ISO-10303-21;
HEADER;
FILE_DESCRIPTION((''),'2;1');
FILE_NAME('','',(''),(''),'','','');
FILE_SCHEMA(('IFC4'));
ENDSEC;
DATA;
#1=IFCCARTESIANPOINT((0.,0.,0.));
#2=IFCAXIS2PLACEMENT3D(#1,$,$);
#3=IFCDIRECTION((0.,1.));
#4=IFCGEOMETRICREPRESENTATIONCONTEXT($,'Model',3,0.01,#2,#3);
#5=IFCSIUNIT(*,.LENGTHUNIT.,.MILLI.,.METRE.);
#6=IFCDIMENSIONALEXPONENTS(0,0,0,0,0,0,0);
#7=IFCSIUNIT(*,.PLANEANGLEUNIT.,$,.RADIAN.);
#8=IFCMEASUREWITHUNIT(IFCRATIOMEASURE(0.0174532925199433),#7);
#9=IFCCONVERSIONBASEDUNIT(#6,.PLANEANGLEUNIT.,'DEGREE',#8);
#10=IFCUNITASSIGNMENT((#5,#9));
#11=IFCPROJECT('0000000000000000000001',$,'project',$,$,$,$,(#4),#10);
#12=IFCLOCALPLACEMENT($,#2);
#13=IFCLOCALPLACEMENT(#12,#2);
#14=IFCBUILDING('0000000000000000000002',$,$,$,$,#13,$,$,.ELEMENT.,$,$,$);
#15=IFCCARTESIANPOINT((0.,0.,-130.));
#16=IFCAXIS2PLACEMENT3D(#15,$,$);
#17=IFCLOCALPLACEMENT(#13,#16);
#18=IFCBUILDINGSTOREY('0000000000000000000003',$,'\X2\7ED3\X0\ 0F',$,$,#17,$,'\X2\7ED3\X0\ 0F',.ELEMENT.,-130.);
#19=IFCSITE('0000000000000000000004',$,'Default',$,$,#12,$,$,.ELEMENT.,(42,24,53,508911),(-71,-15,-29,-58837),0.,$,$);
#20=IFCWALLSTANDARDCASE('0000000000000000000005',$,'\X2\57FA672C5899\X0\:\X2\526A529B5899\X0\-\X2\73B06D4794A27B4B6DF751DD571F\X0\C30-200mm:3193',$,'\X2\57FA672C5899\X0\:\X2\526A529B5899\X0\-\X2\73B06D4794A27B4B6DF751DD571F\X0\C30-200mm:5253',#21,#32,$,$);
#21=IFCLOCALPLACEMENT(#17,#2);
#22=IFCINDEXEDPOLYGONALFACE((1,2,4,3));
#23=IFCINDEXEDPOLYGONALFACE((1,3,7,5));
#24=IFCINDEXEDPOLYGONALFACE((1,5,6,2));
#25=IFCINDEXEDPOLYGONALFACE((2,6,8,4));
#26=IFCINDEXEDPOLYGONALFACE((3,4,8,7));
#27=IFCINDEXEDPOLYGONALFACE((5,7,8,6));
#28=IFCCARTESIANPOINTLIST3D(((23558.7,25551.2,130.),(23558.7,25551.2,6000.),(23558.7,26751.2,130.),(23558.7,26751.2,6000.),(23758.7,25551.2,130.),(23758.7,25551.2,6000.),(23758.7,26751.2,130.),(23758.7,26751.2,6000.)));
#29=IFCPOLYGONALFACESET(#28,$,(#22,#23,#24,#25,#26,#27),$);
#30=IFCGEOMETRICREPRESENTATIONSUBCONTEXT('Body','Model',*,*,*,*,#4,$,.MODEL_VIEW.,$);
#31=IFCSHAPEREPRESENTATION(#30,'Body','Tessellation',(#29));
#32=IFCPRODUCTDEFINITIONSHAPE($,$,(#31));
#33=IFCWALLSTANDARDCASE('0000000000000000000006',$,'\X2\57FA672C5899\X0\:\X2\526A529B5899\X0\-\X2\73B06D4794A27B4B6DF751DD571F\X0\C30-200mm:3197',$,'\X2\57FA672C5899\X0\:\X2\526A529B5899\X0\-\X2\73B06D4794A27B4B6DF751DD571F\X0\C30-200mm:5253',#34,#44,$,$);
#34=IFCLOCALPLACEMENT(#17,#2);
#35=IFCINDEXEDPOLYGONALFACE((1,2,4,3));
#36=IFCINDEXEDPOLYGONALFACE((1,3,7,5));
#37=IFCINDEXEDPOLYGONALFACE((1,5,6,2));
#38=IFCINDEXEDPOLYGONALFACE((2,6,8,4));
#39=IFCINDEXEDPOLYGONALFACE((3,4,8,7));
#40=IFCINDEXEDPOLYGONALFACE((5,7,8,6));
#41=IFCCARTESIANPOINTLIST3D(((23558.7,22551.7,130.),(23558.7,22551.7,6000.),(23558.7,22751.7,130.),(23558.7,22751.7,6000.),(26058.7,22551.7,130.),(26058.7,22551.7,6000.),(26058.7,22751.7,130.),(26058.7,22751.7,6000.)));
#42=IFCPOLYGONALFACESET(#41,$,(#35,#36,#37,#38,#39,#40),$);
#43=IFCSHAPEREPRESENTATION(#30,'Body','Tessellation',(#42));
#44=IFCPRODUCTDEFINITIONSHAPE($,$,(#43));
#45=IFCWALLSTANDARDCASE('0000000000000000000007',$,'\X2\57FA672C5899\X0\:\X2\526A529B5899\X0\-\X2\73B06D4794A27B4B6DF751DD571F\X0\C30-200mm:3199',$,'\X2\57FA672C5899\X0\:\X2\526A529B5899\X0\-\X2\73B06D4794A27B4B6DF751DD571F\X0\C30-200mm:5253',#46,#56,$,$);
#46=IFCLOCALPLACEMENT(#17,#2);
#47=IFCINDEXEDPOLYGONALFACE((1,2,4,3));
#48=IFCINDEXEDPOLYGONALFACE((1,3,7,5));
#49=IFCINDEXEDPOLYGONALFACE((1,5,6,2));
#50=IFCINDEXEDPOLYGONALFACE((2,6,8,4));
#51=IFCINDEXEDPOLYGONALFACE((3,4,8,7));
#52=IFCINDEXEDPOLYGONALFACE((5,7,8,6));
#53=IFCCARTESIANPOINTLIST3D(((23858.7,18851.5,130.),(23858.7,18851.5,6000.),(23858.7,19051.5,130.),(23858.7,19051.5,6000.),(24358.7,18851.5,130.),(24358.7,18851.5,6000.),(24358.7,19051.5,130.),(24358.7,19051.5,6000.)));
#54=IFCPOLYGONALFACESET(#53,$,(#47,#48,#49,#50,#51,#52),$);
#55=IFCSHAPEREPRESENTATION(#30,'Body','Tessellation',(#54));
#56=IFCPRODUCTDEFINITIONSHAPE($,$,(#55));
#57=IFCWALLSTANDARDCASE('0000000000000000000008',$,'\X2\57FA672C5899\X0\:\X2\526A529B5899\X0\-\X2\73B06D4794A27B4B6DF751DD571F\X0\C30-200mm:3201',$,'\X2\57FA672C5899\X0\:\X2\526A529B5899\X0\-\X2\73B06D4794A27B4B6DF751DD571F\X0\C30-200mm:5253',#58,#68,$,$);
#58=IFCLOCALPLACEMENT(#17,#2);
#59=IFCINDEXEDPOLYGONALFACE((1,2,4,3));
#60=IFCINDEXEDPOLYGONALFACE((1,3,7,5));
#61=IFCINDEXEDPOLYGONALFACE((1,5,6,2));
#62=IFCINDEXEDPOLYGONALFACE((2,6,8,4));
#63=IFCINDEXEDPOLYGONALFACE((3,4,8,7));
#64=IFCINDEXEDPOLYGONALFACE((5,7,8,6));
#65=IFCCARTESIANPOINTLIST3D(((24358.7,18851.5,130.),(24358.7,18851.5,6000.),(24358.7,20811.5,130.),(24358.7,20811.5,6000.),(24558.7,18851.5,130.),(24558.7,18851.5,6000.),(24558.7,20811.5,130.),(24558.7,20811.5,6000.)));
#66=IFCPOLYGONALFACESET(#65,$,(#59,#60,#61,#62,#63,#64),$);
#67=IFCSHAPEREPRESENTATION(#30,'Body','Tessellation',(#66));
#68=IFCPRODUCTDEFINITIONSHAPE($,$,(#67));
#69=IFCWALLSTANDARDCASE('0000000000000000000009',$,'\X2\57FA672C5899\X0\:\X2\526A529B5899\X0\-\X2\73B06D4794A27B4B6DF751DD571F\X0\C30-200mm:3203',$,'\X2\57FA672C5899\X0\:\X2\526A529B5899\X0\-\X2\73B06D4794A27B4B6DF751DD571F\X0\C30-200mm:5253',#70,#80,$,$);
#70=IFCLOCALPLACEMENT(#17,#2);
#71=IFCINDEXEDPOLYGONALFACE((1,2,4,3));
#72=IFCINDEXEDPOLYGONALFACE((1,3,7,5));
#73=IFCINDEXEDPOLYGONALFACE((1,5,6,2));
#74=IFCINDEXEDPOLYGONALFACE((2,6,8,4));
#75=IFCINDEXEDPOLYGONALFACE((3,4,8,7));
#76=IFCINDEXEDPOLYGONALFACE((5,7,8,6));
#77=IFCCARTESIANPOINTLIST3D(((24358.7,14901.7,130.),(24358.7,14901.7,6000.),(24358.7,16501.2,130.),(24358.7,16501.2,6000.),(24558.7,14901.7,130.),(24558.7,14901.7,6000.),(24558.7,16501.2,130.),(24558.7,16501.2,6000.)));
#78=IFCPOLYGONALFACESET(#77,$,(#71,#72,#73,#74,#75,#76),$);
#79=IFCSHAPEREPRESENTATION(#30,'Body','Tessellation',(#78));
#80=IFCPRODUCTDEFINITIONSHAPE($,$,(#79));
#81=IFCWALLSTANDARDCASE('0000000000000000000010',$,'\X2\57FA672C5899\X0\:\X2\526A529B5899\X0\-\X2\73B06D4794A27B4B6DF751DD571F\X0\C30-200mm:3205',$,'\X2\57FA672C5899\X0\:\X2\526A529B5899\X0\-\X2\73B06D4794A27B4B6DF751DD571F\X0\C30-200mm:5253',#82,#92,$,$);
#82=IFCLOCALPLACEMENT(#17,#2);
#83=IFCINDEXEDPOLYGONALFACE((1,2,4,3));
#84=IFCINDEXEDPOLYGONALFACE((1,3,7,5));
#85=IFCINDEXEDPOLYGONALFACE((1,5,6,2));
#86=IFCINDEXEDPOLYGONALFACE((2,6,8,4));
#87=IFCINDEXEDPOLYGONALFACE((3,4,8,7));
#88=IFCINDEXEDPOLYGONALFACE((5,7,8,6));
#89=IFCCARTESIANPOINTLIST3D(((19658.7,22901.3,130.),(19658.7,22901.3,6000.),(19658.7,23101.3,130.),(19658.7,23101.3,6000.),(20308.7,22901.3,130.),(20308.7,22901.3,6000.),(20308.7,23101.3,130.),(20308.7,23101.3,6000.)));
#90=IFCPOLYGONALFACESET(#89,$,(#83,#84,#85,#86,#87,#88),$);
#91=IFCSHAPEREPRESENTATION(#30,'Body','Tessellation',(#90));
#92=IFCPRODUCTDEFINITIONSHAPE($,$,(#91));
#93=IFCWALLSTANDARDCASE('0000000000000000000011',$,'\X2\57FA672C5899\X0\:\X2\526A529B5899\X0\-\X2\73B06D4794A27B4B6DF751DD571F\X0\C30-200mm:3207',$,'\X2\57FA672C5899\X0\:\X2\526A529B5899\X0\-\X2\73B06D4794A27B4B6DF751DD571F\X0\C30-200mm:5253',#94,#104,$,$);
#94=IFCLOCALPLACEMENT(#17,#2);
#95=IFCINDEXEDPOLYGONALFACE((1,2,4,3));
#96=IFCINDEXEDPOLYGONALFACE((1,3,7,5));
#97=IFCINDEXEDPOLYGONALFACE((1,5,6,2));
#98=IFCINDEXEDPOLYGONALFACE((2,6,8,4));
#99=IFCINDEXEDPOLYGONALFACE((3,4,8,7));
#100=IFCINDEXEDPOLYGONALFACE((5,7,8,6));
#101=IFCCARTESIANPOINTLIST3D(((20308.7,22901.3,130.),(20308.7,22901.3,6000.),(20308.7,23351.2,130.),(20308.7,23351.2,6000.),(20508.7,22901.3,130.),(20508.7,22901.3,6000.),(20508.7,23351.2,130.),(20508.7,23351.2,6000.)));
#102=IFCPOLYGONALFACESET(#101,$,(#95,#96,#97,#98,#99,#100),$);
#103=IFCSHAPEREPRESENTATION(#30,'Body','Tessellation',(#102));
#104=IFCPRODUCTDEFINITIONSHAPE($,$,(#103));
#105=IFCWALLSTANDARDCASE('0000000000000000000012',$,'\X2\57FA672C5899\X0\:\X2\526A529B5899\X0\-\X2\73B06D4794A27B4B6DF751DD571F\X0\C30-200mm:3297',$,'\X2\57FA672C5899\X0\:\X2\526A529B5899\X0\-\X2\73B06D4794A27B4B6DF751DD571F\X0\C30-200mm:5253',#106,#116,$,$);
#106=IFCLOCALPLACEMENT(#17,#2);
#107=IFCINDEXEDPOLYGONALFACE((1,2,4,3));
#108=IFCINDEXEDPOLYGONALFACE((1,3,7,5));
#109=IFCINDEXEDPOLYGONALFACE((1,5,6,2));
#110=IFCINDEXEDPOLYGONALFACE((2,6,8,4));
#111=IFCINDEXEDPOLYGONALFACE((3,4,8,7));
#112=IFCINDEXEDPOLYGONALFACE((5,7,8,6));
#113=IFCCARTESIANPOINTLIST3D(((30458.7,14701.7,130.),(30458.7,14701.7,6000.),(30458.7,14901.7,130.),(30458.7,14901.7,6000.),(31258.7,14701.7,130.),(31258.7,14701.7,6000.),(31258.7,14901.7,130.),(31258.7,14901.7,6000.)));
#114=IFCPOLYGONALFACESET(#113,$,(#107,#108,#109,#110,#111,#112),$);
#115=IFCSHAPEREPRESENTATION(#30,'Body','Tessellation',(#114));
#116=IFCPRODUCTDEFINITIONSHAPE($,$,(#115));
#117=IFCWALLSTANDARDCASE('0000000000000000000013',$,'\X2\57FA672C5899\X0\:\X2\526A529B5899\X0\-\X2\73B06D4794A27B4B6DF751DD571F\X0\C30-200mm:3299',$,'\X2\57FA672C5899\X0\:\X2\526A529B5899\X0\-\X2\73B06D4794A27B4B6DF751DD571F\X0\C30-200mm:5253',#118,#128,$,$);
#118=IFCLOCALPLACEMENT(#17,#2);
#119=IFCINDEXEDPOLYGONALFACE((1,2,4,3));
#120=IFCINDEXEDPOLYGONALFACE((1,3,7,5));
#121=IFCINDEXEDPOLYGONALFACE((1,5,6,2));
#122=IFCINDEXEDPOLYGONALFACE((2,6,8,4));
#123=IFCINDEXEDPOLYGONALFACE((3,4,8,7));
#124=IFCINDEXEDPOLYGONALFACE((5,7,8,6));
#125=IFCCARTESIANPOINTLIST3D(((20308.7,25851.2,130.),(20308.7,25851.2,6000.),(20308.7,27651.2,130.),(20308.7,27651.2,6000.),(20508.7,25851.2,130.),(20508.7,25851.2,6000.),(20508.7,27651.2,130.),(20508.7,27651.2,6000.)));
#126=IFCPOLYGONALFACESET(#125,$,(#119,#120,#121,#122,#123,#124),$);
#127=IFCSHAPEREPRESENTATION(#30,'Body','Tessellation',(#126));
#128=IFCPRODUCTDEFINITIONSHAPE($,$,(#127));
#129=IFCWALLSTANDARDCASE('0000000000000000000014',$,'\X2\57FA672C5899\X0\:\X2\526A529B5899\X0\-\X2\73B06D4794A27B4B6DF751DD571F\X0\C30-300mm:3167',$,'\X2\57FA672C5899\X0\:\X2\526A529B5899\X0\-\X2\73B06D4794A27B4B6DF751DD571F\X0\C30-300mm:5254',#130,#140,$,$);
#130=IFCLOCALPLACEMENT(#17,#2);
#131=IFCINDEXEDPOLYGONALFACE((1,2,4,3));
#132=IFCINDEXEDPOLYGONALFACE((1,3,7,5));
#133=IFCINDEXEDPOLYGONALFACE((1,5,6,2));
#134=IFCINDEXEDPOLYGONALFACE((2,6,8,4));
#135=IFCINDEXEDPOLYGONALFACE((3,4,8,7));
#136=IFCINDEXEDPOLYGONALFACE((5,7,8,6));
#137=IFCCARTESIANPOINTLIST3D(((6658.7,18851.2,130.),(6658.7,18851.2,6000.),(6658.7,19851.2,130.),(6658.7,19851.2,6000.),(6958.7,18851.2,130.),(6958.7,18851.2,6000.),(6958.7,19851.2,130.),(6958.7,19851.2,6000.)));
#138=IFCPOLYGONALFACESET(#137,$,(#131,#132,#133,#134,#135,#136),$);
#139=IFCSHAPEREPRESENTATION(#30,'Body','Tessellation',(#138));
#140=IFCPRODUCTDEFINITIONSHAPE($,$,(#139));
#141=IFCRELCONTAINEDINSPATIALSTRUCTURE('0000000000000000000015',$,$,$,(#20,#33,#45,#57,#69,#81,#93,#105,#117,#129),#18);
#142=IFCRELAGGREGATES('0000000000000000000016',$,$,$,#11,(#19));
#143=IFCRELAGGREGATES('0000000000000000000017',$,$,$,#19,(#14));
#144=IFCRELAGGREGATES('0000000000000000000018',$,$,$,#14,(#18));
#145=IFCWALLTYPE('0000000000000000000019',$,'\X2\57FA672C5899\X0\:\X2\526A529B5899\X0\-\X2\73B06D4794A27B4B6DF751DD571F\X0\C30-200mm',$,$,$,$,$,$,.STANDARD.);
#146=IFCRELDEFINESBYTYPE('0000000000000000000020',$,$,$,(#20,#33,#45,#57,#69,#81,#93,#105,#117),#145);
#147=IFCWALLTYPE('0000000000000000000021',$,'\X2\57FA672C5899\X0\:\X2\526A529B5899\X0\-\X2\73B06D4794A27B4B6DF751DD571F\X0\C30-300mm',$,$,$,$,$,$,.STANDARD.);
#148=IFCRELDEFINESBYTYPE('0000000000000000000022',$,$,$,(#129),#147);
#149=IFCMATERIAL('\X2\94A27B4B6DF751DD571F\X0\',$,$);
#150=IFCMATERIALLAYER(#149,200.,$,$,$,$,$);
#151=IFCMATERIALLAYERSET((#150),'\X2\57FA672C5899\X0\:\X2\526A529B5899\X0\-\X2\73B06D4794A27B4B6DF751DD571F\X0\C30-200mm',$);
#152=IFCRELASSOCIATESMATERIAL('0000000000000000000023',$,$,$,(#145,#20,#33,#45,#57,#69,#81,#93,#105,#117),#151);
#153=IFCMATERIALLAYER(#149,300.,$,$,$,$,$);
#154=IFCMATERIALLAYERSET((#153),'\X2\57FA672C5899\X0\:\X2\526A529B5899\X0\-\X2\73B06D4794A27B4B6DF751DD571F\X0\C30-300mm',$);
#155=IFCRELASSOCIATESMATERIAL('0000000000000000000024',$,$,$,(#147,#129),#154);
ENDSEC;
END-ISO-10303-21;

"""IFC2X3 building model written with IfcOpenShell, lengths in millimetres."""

from ifc_helpers import new_model, entity, si_unit, converted_unit, direction, frame, frame_2d, origin, place, context, subcontext, project, spatial, rectangle, extrude, material, layer, layer_set, layer_usage, type_object, element, save


model = new_model("IFC2X3")

# Units and contexts
model_context = context("Model", 3, precision=0.01, world=origin(), true_north=direction((0.0, 1.0)))
body_context = subcontext(model_context, "Body", "Model", "MODEL_VIEW")
ifc_project = project(units=[si_unit("LENGTHUNIT", "METRE", prefix="MILLI"), converted_unit("PLANEANGLEUNIT", "DEGREE", entity("IfcRatioMeasure", 0.0174532925199433), si_unit("PLANEANGLEUNIT", "RADIAN"), dimensions=[0, 0, 0, 0, 0, 0, 0])], contexts=[model_context])

# Site, building, storey
site_placement = place(None, origin())
site = spatial("IfcSite", under=ifc_project, at=site_placement, Name="Default", CompositionType="ELEMENT", RefLatitude=(42, 24, 53, 508911), RefLongitude=(-71, -15, -29, -58837), RefElevation=0.0)
building_placement = place(site_placement, origin())
building = spatial("IfcBuilding", under=site, at=building_placement, CompositionType="ELEMENT")
storey_placement = place(building_placement, frame((0.0, 0.0, -130.0)))
storey = spatial("IfcBuildingStorey", under=building, at=storey_placement, Name="结 0F", LongName="结 0F", CompositionType="ELEMENT", Elevation=-130.0)

# Walls
ifc_material = material(Name="钢筋混凝土")
ifc_layer_1 = layer(ifc_material, 200.0)
ifc_layer_set_1 = layer_set([ifc_layer_1], Name="基本墙:剪力墙-现浇钢筋混凝土C30-200mm")
wall_type_1 = type_object("IfcWallType", Name="基本墙:剪力墙-现浇钢筋混凝土C30-200mm", PredefinedType="STANDARD", material=ifc_layer_set_1)
ifc_layer_usage_1 = layer_usage(ifc_layer_set_1, "AXIS2", "POSITIVE", -100.0)
wall_1_placement = place(storey_placement, frame((23658.7, 26751.2, 130.0), z_axis=(0.0, 0.0, 1.0), x_axis=(0.0, -1.0, 0.0)))
element("IfcWallStandardCase", 1, at=wall_1_placement, inside=storey, type_object=wall_type_1, material=ifc_layer_usage_1, Name="基本墙:剪力墙-现浇钢筋混凝土C30-200mm:3193", ObjectType="基本墙:剪力墙-现浇钢筋混凝土C30-200mm:5253", context=body_context, shape_type="SweptSolid", body=[
    extrude(rectangle(XDim=1200.0, YDim=200.0, at=frame_2d((600.0, 0.0), x_axis=(-1.0, 0.0))), origin(), (0.0, 0.0, 1.0), 5870.0),
])
ifc_layer_usage_2 = layer_usage(ifc_layer_set_1, "AXIS2", "POSITIVE", -100.0)
wall_2_placement = place(storey_placement, frame((26058.7, 22651.7, 130.0), z_axis=(0.0, 0.0, 1.0), x_axis=(-1.0, 0.0, 0.0)))
element("IfcWallStandardCase", 2, at=wall_2_placement, inside=storey, type_object=wall_type_1, material=ifc_layer_usage_2, Name="基本墙:剪力墙-现浇钢筋混凝土C30-200mm:3197", ObjectType="基本墙:剪力墙-现浇钢筋混凝土C30-200mm:5253", context=body_context, shape_type="SweptSolid", body=[
    extrude(rectangle(XDim=2500.0, YDim=200.0, at=frame_2d((1250.0, 0.0), x_axis=(-1.0, 0.0))), origin(), (0.0, 0.0, 1.0), 5870.0),
])
ifc_layer_usage_3 = layer_usage(ifc_layer_set_1, "AXIS2", "POSITIVE", -100.0)
wall_3_placement = place(storey_placement, frame((23858.7, 18951.5, 130.0)))
element("IfcWallStandardCase", 3, at=wall_3_placement, inside=storey, type_object=wall_type_1, material=ifc_layer_usage_3, Name="基本墙:剪力墙-现浇钢筋混凝土C30-200mm:3199", ObjectType="基本墙:剪力墙-现浇钢筋混凝土C30-200mm:5253", context=body_context, shape_type="SweptSolid", body=[
    extrude(rectangle(XDim=500.0, YDim=200.0, at=frame_2d((250.0, 0.0), x_axis=(-1.0, 0.0))), origin(), (0.0, 0.0, 1.0), 5870.0),
])
ifc_layer_usage_4 = layer_usage(ifc_layer_set_1, "AXIS2", "POSITIVE", -100.0)
wall_4_placement = place(storey_placement, frame((24458.7, 18851.5, 130.0), z_axis=(0.0, 0.0, 1.0), x_axis=(0.0, 1.0, 0.0)))
element("IfcWallStandardCase", 4, at=wall_4_placement, inside=storey, type_object=wall_type_1, material=ifc_layer_usage_4, Name="基本墙:剪力墙-现浇钢筋混凝土C30-200mm:3201", ObjectType="基本墙:剪力墙-现浇钢筋混凝土C30-200mm:5253", context=body_context, shape_type="SweptSolid", body=[
    extrude(rectangle(XDim=1960.0, YDim=200.0, at=frame_2d((980.0, 0.0), x_axis=(-1.0, 0.0))), origin(), (0.0, 0.0, 1.0), 5870.0),
])
ifc_layer_usage_5 = layer_usage(ifc_layer_set_1, "AXIS2", "POSITIVE", -100.0)
wall_5_placement = place(storey_placement, frame((24458.7, 14901.7, 130.0), z_axis=(0.0, 0.0, 1.0), x_axis=(0.0, 1.0, 0.0)))
element("IfcWallStandardCase", 5, at=wall_5_placement, inside=storey, type_object=wall_type_1, material=ifc_layer_usage_5, Name="基本墙:剪力墙-现浇钢筋混凝土C30-200mm:3203", ObjectType="基本墙:剪力墙-现浇钢筋混凝土C30-200mm:5253", context=body_context, shape_type="SweptSolid", body=[
    extrude(rectangle(XDim=1599.5, YDim=200.0, at=frame_2d((799.8, 0.0), x_axis=(-1.0, 0.0))), origin(), (0.0, 0.0, 1.0), 5870.0),
])
ifc_layer_usage_6 = layer_usage(ifc_layer_set_1, "AXIS2", "POSITIVE", -100.0)
wall_6_placement = place(storey_placement, frame((20308.7, 23001.3, 130.0), z_axis=(0.0, 0.0, 1.0), x_axis=(-1.0, 0.0, 0.0)))
element("IfcWallStandardCase", 6, at=wall_6_placement, inside=storey, type_object=wall_type_1, material=ifc_layer_usage_6, Name="基本墙:剪力墙-现浇钢筋混凝土C30-200mm:3205", ObjectType="基本墙:剪力墙-现浇钢筋混凝土C30-200mm:5253", context=body_context, shape_type="SweptSolid", body=[
    extrude(rectangle(XDim=650.0, YDim=200.0, at=frame_2d((325.0, 0.0), x_axis=(-1.0, 0.0))), origin(), (0.0, 0.0, 1.0), 5870.0),
])
ifc_layer_usage_7 = layer_usage(ifc_layer_set_1, "AXIS2", "POSITIVE", -100.0)
wall_7_placement = place(storey_placement, frame((20408.7, 22901.3, 130.0), z_axis=(0.0, 0.0, 1.0), x_axis=(0.0, 1.0, 0.0)))
element("IfcWallStandardCase", 7, at=wall_7_placement, inside=storey, type_object=wall_type_1, material=ifc_layer_usage_7, Name="基本墙:剪力墙-现浇钢筋混凝土C30-200mm:3207", ObjectType="基本墙:剪力墙-现浇钢筋混凝土C30-200mm:5253", context=body_context, shape_type="SweptSolid", body=[
    extrude(rectangle(XDim=449.9, YDim=200.0, at=frame_2d((225.0, 0.0), x_axis=(-1.0, 0.0))), origin(), (0.0, 0.0, 1.0), 5870.0),
])
ifc_layer_usage_8 = layer_usage(ifc_layer_set_1, "AXIS2", "NEGATIVE", 100.0)
wall_8_placement = place(storey_placement, frame((31258.7, 14801.7, 130.0), z_axis=(0.0, 0.0, 1.0), x_axis=(-1.0, 0.0, 0.0)))
element("IfcWallStandardCase", 8, at=wall_8_placement, inside=storey, type_object=wall_type_1, material=ifc_layer_usage_8, Name="基本墙:剪力墙-现浇钢筋混凝土C30-200mm:3297", ObjectType="基本墙:剪力墙-现浇钢筋混凝土C30-200mm:5253", context=body_context, shape_type="SweptSolid", body=[
    extrude(rectangle(XDim=800.0, YDim=200.0, at=frame_2d((400.0, 0.0), x_axis=(-1.0, 0.0))), origin(), (0.0, 0.0, 1.0), 5870.0),
])
ifc_layer_usage_9 = layer_usage(ifc_layer_set_1, "AXIS2", "NEGATIVE", 100.0)
wall_9_placement = place(storey_placement, frame((20408.7, 25851.2, 130.0), z_axis=(0.0, 0.0, 1.0), x_axis=(0.0, 1.0, 0.0)))
element("IfcWallStandardCase", 9, at=wall_9_placement, inside=storey, type_object=wall_type_1, material=ifc_layer_usage_9, Name="基本墙:剪力墙-现浇钢筋混凝土C30-200mm:3299", ObjectType="基本墙:剪力墙-现浇钢筋混凝土C30-200mm:5253", context=body_context, shape_type="SweptSolid", body=[
    extrude(rectangle(XDim=1800.0, YDim=200.0, at=frame_2d((900.0, 0.0), x_axis=(-1.0, 0.0))), origin(), (0.0, 0.0, 1.0), 5870.0),
])
ifc_layer_2 = layer(ifc_material, 300.0)
ifc_layer_set_2 = layer_set([ifc_layer_2], Name="基本墙:剪力墙-现浇钢筋混凝土C30-300mm")
ifc_layer_usage_10 = layer_usage(ifc_layer_set_2, "AXIS2", "NEGATIVE", 150.0)
wall_type_2 = type_object("IfcWallType", Name="基本墙:剪力墙-现浇钢筋混凝土C30-300mm", PredefinedType="STANDARD", material=ifc_layer_set_2)
wall_10_placement = place(storey_placement, frame((6808.7, 19851.2, 130.0), z_axis=(0.0, 0.0, 1.0), x_axis=(0.0, -1.0, 0.0)))
element("IfcWallStandardCase", 10, at=wall_10_placement, inside=storey, type_object=wall_type_2, material=ifc_layer_usage_10, Name="基本墙:剪力墙-现浇钢筋混凝土C30-300mm:3167", ObjectType="基本墙:剪力墙-现浇钢筋混凝土C30-300mm:5254", context=body_context, shape_type="SweptSolid", body=[
    extrude(rectangle(XDim=1000.0, YDim=300.0, at=frame_2d((500.0, 0.0), x_axis=(-1.0, 0.0))), origin(), (0.0, 0.0, 1.0), 5870.0),
])

save(model, "model.ifc")
